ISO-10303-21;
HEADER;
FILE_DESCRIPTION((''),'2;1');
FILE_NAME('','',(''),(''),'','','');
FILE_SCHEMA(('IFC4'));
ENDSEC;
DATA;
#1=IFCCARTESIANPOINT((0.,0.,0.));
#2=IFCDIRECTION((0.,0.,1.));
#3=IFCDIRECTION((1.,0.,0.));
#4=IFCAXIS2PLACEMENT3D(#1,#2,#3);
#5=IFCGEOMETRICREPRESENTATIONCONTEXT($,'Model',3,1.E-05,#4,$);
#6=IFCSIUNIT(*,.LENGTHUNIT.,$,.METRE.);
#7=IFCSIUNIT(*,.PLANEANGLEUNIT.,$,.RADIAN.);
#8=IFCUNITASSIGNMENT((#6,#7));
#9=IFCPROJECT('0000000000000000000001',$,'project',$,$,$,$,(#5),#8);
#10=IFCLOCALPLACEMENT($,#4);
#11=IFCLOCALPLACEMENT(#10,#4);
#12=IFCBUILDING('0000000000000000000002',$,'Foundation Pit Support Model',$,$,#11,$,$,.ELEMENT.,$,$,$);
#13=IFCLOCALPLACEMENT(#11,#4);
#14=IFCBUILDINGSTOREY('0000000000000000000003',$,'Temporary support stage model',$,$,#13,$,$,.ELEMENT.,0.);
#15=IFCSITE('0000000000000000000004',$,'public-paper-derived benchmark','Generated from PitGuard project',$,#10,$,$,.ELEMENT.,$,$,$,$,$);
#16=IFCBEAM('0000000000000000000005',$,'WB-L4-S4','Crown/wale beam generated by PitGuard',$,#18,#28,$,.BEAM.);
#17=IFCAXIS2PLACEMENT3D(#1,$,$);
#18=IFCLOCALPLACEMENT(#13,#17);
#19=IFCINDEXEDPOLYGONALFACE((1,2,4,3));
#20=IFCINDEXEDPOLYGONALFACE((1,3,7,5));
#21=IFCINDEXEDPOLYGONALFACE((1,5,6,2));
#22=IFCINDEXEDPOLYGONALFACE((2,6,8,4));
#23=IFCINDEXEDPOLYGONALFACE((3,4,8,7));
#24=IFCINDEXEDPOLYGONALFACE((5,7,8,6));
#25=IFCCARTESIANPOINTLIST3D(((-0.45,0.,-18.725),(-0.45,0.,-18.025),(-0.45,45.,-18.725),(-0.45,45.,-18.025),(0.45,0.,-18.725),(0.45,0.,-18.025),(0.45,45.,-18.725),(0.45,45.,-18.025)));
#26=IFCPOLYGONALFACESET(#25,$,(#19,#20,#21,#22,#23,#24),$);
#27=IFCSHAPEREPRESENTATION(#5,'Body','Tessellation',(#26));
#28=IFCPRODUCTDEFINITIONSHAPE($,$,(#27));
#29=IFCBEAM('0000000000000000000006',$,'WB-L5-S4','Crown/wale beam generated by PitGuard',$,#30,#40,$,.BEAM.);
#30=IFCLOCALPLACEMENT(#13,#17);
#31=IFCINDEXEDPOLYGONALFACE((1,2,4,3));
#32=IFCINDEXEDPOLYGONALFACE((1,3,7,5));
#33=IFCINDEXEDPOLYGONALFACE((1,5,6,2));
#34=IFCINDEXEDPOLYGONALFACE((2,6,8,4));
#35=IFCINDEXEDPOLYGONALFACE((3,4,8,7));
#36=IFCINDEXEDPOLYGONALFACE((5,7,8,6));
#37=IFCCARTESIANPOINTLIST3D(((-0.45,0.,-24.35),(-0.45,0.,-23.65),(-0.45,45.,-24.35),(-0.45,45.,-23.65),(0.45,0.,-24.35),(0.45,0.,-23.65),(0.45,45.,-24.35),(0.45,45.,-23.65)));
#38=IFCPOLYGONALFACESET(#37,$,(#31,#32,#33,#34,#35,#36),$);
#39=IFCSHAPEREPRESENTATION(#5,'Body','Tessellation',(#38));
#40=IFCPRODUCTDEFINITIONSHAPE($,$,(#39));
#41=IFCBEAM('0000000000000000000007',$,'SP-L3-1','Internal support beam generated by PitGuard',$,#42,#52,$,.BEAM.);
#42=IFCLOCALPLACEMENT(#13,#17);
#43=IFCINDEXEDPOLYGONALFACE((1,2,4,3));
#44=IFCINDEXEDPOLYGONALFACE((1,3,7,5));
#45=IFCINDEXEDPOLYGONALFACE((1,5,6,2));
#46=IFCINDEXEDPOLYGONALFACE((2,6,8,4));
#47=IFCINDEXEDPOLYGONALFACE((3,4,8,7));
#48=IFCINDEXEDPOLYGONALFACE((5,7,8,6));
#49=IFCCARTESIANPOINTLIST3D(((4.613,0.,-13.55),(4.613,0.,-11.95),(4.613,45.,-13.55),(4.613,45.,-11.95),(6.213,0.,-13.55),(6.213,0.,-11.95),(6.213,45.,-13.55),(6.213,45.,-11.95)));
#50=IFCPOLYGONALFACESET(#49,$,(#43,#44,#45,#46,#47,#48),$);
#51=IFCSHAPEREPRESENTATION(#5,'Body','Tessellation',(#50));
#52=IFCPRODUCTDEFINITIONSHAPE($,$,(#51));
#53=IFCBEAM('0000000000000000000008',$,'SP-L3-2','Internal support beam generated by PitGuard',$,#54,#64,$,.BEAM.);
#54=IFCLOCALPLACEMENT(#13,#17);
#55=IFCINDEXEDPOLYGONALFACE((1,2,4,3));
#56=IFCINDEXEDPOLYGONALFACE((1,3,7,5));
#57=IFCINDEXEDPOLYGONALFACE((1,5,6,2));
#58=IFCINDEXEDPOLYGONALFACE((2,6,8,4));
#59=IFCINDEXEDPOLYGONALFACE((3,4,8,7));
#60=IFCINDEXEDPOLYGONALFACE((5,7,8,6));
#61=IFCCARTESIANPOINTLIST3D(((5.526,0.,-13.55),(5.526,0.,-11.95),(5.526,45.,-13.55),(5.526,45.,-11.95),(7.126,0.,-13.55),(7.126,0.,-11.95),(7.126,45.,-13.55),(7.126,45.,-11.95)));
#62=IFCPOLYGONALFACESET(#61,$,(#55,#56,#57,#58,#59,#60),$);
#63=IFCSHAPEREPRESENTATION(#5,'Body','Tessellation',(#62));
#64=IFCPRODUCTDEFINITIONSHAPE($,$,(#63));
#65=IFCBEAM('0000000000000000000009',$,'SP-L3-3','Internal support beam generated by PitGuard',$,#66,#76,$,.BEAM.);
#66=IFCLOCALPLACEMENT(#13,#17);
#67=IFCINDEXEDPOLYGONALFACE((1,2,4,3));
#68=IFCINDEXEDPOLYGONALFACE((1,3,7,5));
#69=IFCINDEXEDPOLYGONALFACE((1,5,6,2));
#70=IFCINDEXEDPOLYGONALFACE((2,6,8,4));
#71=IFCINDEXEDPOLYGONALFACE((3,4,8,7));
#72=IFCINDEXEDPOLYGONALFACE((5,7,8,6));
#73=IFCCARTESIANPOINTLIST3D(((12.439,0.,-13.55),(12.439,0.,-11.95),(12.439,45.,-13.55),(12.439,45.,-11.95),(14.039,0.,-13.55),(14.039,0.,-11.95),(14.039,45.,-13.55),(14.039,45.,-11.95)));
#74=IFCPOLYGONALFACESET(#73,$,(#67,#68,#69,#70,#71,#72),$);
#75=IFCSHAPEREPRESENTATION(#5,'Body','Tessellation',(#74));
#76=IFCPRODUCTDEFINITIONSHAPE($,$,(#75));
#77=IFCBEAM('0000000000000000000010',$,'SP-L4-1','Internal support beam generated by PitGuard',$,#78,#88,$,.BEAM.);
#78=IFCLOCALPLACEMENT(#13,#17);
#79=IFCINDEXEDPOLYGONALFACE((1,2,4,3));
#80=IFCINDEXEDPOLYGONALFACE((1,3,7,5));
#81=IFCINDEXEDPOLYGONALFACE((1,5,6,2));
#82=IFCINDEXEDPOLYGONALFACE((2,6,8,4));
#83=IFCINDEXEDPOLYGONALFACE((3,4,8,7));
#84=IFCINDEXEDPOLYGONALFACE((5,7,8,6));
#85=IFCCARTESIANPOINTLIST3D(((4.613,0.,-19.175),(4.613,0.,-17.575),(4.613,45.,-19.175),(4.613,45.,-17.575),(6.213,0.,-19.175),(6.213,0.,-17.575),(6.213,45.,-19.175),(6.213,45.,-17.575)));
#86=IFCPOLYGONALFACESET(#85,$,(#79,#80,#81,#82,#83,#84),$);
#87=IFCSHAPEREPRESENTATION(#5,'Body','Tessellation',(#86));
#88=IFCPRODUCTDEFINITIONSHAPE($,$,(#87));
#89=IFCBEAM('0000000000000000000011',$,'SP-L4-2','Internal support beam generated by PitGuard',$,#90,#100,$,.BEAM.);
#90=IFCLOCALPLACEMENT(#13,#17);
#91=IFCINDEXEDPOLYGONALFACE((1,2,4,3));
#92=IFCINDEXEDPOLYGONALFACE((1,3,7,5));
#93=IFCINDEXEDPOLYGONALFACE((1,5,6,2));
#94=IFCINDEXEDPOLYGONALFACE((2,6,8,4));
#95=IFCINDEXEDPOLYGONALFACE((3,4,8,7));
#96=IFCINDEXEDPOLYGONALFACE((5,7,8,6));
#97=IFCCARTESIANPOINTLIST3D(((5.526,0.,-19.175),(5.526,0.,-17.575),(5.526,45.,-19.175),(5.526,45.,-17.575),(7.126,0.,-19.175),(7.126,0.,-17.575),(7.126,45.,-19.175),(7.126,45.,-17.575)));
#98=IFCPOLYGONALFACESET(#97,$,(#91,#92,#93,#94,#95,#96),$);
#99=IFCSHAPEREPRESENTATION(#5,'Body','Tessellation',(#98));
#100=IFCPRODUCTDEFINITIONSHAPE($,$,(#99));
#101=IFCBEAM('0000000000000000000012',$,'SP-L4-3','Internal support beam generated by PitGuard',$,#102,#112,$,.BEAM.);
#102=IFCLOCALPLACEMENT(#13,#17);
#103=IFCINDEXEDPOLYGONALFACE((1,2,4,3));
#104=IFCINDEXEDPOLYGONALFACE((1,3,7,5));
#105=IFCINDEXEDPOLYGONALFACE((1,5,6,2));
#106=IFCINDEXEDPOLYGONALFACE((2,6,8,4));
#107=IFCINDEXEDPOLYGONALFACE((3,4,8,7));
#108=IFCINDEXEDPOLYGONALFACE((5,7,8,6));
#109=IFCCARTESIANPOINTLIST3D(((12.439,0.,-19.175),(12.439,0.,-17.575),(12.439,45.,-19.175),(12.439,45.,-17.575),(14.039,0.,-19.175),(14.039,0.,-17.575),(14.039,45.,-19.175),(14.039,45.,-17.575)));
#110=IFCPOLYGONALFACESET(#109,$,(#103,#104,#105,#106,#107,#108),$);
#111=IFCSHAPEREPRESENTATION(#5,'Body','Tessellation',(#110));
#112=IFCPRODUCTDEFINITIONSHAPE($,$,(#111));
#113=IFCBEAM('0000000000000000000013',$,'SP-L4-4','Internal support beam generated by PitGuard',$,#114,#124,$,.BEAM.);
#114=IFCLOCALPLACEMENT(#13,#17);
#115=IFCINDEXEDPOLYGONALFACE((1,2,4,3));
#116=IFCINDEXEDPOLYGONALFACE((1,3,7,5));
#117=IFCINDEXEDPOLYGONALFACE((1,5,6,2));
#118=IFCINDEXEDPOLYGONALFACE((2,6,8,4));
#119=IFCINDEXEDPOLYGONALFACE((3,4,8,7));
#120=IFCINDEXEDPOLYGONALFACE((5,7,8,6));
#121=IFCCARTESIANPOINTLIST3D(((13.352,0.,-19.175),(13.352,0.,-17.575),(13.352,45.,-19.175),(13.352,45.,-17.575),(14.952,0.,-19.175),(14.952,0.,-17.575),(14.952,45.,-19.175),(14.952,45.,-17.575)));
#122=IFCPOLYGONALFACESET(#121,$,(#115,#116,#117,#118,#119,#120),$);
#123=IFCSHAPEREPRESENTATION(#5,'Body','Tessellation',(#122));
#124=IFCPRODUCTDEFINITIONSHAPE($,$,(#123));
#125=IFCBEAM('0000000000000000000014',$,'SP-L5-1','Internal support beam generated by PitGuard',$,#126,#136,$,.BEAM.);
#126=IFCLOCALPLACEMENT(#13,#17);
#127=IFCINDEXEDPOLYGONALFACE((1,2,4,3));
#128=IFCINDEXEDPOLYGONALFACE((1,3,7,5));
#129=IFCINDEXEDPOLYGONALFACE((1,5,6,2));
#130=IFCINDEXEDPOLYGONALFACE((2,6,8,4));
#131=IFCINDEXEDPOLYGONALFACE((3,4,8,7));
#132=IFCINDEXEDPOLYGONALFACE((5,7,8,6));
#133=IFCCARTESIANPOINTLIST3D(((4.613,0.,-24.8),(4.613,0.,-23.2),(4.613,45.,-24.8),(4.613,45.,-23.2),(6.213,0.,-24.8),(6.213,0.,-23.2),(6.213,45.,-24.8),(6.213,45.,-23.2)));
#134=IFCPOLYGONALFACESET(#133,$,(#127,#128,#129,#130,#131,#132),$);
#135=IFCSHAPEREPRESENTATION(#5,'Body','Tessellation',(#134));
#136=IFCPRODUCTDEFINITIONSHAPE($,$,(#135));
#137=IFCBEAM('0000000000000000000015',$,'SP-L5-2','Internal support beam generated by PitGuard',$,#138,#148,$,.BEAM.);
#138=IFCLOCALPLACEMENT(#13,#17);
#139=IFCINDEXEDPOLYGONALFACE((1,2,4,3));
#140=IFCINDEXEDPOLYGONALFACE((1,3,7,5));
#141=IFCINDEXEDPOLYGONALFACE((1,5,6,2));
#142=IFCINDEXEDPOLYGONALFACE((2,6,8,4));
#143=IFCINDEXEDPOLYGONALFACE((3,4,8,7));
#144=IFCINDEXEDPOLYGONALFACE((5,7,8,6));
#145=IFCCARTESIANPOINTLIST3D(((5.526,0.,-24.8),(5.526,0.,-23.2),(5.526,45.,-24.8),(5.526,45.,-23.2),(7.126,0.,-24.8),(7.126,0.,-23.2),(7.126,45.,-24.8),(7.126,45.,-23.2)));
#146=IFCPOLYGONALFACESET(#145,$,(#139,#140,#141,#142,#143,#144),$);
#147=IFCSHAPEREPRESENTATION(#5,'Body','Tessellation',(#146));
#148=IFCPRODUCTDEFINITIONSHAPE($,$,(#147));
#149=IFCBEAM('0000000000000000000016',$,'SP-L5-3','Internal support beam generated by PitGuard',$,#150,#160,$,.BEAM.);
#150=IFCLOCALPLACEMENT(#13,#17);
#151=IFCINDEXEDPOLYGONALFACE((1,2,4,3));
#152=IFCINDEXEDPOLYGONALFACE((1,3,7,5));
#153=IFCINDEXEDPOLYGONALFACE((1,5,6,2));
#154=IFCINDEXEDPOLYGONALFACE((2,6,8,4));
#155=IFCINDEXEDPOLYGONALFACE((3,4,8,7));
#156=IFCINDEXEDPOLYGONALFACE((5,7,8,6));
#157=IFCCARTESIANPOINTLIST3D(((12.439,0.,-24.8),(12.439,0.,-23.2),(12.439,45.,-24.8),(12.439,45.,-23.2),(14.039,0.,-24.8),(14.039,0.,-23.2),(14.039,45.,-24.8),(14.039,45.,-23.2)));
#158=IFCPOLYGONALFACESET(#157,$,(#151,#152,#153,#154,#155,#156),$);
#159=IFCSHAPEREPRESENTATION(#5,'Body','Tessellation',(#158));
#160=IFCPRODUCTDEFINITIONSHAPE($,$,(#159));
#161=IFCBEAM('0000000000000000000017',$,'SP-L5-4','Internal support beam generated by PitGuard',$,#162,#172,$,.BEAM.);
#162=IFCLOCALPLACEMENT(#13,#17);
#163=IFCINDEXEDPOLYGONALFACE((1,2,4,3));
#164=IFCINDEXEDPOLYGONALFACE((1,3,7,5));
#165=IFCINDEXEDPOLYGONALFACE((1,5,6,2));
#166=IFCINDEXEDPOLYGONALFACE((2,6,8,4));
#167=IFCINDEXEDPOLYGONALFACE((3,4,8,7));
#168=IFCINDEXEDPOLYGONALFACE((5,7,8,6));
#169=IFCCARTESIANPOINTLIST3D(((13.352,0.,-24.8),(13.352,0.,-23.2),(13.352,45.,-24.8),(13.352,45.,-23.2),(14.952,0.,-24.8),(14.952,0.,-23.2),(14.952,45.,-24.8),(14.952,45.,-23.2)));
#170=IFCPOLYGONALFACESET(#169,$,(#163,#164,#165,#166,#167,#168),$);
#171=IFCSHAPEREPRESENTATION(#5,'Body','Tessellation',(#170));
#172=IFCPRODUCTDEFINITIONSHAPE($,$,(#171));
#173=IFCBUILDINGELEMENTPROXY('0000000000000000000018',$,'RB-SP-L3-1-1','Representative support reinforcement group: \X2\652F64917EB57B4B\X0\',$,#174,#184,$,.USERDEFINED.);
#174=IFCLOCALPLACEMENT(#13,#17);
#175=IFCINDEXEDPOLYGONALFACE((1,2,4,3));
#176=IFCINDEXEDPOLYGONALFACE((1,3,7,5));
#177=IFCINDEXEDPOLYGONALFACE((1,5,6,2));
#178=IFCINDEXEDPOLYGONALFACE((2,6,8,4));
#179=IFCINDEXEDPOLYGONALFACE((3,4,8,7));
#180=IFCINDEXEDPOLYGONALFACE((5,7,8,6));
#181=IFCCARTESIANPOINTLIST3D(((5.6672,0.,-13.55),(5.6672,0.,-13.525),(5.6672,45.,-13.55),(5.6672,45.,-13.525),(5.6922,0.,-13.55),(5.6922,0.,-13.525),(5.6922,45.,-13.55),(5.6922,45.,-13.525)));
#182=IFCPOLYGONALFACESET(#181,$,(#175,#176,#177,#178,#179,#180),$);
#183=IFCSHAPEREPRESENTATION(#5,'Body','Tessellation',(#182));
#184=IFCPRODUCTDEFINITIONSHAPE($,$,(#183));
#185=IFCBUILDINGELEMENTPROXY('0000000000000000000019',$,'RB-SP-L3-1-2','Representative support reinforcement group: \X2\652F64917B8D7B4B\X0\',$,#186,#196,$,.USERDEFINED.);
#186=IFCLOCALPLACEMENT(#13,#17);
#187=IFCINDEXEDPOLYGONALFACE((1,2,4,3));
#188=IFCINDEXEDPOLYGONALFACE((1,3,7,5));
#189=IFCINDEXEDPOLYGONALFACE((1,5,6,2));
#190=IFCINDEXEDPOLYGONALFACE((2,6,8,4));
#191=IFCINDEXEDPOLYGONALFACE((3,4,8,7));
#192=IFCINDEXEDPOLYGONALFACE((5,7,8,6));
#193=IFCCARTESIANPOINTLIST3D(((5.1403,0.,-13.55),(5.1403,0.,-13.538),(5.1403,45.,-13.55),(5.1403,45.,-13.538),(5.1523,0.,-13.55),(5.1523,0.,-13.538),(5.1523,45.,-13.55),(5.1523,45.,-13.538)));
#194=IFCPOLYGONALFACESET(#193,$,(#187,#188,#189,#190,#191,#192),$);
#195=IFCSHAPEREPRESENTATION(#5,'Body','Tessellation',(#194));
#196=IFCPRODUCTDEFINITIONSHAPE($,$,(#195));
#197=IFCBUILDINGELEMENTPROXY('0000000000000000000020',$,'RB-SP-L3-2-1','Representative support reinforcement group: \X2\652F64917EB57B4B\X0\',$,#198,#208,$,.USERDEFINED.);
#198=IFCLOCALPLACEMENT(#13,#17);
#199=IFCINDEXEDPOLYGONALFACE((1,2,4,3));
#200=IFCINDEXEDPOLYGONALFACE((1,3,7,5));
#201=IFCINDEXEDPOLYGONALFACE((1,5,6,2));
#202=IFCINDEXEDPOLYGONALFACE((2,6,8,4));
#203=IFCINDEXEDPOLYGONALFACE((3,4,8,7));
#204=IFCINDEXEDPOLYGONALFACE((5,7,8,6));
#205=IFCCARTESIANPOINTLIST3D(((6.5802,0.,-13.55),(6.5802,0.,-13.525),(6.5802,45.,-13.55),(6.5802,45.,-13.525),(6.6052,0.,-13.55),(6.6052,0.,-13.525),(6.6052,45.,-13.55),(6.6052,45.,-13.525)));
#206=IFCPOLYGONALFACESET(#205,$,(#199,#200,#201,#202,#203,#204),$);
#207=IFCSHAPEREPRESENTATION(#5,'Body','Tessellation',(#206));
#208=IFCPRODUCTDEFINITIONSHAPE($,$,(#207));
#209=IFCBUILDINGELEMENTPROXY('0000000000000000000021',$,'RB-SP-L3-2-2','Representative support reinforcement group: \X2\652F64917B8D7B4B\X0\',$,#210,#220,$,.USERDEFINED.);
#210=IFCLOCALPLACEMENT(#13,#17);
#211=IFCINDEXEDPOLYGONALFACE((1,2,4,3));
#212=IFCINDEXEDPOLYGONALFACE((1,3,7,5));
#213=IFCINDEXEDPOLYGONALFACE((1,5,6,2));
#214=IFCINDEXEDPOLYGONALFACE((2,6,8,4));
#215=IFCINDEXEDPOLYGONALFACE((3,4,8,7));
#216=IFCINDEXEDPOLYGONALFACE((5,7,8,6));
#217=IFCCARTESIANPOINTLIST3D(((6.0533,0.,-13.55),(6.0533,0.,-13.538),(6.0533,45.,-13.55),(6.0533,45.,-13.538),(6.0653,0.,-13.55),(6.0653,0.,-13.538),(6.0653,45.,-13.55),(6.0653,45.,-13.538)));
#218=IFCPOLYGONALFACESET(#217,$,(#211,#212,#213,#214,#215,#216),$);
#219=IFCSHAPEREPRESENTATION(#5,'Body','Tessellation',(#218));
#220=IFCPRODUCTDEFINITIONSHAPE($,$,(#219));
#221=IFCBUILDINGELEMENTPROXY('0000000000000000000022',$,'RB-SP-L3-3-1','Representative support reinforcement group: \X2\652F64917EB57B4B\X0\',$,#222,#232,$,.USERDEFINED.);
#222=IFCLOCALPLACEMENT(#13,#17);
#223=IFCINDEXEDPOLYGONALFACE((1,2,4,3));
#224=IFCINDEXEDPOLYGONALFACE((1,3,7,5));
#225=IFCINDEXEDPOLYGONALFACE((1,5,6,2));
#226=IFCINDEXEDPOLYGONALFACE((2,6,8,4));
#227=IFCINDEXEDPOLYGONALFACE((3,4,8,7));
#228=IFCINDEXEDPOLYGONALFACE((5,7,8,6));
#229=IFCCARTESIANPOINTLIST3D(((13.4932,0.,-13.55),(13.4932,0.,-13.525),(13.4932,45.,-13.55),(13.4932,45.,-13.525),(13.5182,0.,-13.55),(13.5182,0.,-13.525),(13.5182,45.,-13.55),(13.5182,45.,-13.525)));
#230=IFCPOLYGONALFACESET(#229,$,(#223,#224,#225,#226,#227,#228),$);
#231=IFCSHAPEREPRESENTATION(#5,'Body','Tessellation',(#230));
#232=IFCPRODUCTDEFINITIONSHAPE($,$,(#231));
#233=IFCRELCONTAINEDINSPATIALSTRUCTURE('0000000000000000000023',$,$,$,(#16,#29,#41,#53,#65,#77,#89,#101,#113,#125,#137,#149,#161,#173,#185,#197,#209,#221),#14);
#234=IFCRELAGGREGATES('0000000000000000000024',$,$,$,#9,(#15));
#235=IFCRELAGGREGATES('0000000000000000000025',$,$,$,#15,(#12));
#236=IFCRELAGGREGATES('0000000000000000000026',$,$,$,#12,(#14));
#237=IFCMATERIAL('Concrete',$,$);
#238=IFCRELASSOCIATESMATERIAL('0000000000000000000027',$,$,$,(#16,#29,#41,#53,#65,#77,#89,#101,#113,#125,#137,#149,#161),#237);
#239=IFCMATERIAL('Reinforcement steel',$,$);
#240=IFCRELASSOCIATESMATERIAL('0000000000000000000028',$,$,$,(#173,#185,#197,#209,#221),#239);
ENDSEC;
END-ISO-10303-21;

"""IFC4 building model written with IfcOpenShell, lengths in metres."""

from ifc_helpers import new_model, si_unit, frame, origin_with_axes, origin_2d, place, context, project, spatial, rectangle, extrude, material, element, save


model = new_model("IFC4")

# Units and contexts
model_context = context("Model", 3, precision=1e-05, world=origin_with_axes())
ifc_project = project(units=[si_unit("LENGTHUNIT", "METRE"), si_unit("PLANEANGLEUNIT", "RADIAN")], contexts=[model_context])

# Site, building, storey
site_placement = place(None, origin_with_axes())
site = spatial("IfcSite", under=ifc_project, at=site_placement, Name="public-paper-derived benchmark", Description="Generated from PitGuard project", CompositionType="ELEMENT")
building_placement = place(site_placement, origin_with_axes())
building = spatial("IfcBuilding", under=site, at=building_placement, Name="Foundation Pit Support Model", CompositionType="ELEMENT")
storey_placement = place(building_placement, origin_with_axes())
storey = spatial("IfcBuildingStorey", under=building, at=storey_placement, Name="Temporary support stage model", CompositionType="ELEMENT", Elevation=0.0)

# Beams
ifc_material_1 = material(Name="Concrete")
for number, where, z_axis, x_axis, name in (
    (1, (0.0, 22.5, -18.725), (0.0, 0.0, 1.0), (0.0, -1.0, 0.0), "WB-L4-S4"),
    (2, (0.0, 22.5, -24.35), (0.0, 0.0, 1.0), (0.0, -1.0, 0.0), "WB-L5-S4"),
):
    element("IfcBeam", number, at=place(storey_placement, frame(where, z_axis=z_axis, x_axis=x_axis)), inside=storey, material=ifc_material_1, Name=name, Description="Crown/wale beam generated by PitGuard", PredefinedType="BEAM", context=model_context, shape_type="SweptSolid", body=[
        extrude(rectangle(XDim=45.0, YDim=0.9, at=origin_2d()), origin_with_axes(), (0.0, 0.0, 1.0), 0.7),
    ])
for number, where, z_axis, x_axis, name in (
    (3, (5.413, 22.5, -13.55), (0.0, 0.0, 1.0), (0.0, 1.0, 0.0), "SP-L3-1"),
    (4, (6.326, 22.5, -13.55), (0.0, 0.0, 1.0), (0.0, 1.0, 0.0), "SP-L3-2"),
    (5, (13.239, 22.5, -13.55), (0.0, 0.0, 1.0), (0.0, 1.0, 0.0), "SP-L3-3"),
    (6, (5.413, 22.5, -19.175), (0.0, 0.0, 1.0), (0.0, 1.0, 0.0), "SP-L4-1"),
    (7, (6.326, 22.5, -19.175), (0.0, 0.0, 1.0), (0.0, 1.0, 0.0), "SP-L4-2"),
    (8, (13.239, 22.5, -19.175), (0.0, 0.0, 1.0), (0.0, 1.0, 0.0), "SP-L4-3"),
    (9, (14.152, 22.5, -19.175), (0.0, 0.0, 1.0), (0.0, 1.0, 0.0), "SP-L4-4"),
    (10, (5.413, 22.5, -24.8), (0.0, 0.0, 1.0), (0.0, 1.0, 0.0), "SP-L5-1"),
    (11, (6.326, 22.5, -24.8), (0.0, 0.0, 1.0), (0.0, 1.0, 0.0), "SP-L5-2"),
    (12, (13.239, 22.5, -24.8), (0.0, 0.0, 1.0), (0.0, 1.0, 0.0), "SP-L5-3"),
    (13, (14.152, 22.5, -24.8), (0.0, 0.0, 1.0), (0.0, 1.0, 0.0), "SP-L5-4"),
):
    element("IfcBeam", number, at=place(storey_placement, frame(where, z_axis=z_axis, x_axis=x_axis)), inside=storey, material=ifc_material_1, Name=name, Description="Internal support beam generated by PitGuard", PredefinedType="BEAM", context=model_context, shape_type="SweptSolid", body=[
        extrude(rectangle(XDim=45.0, YDim=1.6, at=origin_2d()), origin_with_axes(), (0.0, 0.0, 1.0), 1.6),
    ])

# Building element proxies
ifc_material_2 = material(Name="Reinforcement steel")
proxy_1_placement = place(storey_placement, frame((5.6797, 22.5, -13.55), z_axis=(0.0, 0.0, 1.0), x_axis=(0.0, 1.0, 0.0)))
element("IfcBuildingElementProxy", 14, at=proxy_1_placement, inside=storey, material=ifc_material_2, Name="RB-SP-L3-1-1", Description="Representative support reinforcement group: 支撑纵筋", PredefinedType="USERDEFINED", context=model_context, shape_type="SweptSolid", body=[
    extrude(rectangle(XDim=45.0, YDim=0.025, at=origin_2d()), origin_with_axes(), (0.0, 0.0, 1.0), 0.025),
])
proxy_2_placement = place(storey_placement, frame((5.1463, 22.5, -13.55), z_axis=(0.0, 0.0, 1.0), x_axis=(0.0, 1.0, 0.0)))
element("IfcBuildingElementProxy", 15, at=proxy_2_placement, inside=storey, material=ifc_material_2, Name="RB-SP-L3-1-2", Description="Representative support reinforcement group: 支撑箍筋", PredefinedType="USERDEFINED", context=model_context, shape_type="SweptSolid", body=[
    extrude(rectangle(XDim=45.0, YDim=0.012, at=origin_2d()), origin_with_axes(), (0.0, 0.0, 1.0), 0.012),
])
proxy_3_placement = place(storey_placement, frame((6.5927, 22.5, -13.55), z_axis=(0.0, 0.0, 1.0), x_axis=(0.0, 1.0, 0.0)))
element("IfcBuildingElementProxy", 16, at=proxy_3_placement, inside=storey, material=ifc_material_2, Name="RB-SP-L3-2-1", Description="Representative support reinforcement group: 支撑纵筋", PredefinedType="USERDEFINED", context=model_context, shape_type="SweptSolid", body=[
    extrude(rectangle(XDim=45.0, YDim=0.025, at=origin_2d()), origin_with_axes(), (0.0, 0.0, 1.0), 0.025),
])
proxy_4_placement = place(storey_placement, frame((6.0593, 22.5, -13.55), z_axis=(0.0, 0.0, 1.0), x_axis=(0.0, 1.0, 0.0)))
element("IfcBuildingElementProxy", 17, at=proxy_4_placement, inside=storey, material=ifc_material_2, Name="RB-SP-L3-2-2", Description="Representative support reinforcement group: 支撑箍筋", PredefinedType="USERDEFINED", context=model_context, shape_type="SweptSolid", body=[
    extrude(rectangle(XDim=45.0, YDim=0.012, at=origin_2d()), origin_with_axes(), (0.0, 0.0, 1.0), 0.012),
])
proxy_5_placement = place(storey_placement, frame((13.5057, 22.5, -13.55), z_axis=(0.0, 0.0, 1.0), x_axis=(0.0, 1.0, 0.0)))
element("IfcBuildingElementProxy", 18, at=proxy_5_placement, inside=storey, material=ifc_material_2, Name="RB-SP-L3-3-1", Description="Representative support reinforcement group: 支撑纵筋", PredefinedType="USERDEFINED", context=model_context, shape_type="SweptSolid", body=[
    extrude(rectangle(XDim=45.0, YDim=0.025, at=origin_2d()), origin_with_axes(), (0.0, 0.0, 1.0), 0.025),
])

save(model, "model.ifc")
